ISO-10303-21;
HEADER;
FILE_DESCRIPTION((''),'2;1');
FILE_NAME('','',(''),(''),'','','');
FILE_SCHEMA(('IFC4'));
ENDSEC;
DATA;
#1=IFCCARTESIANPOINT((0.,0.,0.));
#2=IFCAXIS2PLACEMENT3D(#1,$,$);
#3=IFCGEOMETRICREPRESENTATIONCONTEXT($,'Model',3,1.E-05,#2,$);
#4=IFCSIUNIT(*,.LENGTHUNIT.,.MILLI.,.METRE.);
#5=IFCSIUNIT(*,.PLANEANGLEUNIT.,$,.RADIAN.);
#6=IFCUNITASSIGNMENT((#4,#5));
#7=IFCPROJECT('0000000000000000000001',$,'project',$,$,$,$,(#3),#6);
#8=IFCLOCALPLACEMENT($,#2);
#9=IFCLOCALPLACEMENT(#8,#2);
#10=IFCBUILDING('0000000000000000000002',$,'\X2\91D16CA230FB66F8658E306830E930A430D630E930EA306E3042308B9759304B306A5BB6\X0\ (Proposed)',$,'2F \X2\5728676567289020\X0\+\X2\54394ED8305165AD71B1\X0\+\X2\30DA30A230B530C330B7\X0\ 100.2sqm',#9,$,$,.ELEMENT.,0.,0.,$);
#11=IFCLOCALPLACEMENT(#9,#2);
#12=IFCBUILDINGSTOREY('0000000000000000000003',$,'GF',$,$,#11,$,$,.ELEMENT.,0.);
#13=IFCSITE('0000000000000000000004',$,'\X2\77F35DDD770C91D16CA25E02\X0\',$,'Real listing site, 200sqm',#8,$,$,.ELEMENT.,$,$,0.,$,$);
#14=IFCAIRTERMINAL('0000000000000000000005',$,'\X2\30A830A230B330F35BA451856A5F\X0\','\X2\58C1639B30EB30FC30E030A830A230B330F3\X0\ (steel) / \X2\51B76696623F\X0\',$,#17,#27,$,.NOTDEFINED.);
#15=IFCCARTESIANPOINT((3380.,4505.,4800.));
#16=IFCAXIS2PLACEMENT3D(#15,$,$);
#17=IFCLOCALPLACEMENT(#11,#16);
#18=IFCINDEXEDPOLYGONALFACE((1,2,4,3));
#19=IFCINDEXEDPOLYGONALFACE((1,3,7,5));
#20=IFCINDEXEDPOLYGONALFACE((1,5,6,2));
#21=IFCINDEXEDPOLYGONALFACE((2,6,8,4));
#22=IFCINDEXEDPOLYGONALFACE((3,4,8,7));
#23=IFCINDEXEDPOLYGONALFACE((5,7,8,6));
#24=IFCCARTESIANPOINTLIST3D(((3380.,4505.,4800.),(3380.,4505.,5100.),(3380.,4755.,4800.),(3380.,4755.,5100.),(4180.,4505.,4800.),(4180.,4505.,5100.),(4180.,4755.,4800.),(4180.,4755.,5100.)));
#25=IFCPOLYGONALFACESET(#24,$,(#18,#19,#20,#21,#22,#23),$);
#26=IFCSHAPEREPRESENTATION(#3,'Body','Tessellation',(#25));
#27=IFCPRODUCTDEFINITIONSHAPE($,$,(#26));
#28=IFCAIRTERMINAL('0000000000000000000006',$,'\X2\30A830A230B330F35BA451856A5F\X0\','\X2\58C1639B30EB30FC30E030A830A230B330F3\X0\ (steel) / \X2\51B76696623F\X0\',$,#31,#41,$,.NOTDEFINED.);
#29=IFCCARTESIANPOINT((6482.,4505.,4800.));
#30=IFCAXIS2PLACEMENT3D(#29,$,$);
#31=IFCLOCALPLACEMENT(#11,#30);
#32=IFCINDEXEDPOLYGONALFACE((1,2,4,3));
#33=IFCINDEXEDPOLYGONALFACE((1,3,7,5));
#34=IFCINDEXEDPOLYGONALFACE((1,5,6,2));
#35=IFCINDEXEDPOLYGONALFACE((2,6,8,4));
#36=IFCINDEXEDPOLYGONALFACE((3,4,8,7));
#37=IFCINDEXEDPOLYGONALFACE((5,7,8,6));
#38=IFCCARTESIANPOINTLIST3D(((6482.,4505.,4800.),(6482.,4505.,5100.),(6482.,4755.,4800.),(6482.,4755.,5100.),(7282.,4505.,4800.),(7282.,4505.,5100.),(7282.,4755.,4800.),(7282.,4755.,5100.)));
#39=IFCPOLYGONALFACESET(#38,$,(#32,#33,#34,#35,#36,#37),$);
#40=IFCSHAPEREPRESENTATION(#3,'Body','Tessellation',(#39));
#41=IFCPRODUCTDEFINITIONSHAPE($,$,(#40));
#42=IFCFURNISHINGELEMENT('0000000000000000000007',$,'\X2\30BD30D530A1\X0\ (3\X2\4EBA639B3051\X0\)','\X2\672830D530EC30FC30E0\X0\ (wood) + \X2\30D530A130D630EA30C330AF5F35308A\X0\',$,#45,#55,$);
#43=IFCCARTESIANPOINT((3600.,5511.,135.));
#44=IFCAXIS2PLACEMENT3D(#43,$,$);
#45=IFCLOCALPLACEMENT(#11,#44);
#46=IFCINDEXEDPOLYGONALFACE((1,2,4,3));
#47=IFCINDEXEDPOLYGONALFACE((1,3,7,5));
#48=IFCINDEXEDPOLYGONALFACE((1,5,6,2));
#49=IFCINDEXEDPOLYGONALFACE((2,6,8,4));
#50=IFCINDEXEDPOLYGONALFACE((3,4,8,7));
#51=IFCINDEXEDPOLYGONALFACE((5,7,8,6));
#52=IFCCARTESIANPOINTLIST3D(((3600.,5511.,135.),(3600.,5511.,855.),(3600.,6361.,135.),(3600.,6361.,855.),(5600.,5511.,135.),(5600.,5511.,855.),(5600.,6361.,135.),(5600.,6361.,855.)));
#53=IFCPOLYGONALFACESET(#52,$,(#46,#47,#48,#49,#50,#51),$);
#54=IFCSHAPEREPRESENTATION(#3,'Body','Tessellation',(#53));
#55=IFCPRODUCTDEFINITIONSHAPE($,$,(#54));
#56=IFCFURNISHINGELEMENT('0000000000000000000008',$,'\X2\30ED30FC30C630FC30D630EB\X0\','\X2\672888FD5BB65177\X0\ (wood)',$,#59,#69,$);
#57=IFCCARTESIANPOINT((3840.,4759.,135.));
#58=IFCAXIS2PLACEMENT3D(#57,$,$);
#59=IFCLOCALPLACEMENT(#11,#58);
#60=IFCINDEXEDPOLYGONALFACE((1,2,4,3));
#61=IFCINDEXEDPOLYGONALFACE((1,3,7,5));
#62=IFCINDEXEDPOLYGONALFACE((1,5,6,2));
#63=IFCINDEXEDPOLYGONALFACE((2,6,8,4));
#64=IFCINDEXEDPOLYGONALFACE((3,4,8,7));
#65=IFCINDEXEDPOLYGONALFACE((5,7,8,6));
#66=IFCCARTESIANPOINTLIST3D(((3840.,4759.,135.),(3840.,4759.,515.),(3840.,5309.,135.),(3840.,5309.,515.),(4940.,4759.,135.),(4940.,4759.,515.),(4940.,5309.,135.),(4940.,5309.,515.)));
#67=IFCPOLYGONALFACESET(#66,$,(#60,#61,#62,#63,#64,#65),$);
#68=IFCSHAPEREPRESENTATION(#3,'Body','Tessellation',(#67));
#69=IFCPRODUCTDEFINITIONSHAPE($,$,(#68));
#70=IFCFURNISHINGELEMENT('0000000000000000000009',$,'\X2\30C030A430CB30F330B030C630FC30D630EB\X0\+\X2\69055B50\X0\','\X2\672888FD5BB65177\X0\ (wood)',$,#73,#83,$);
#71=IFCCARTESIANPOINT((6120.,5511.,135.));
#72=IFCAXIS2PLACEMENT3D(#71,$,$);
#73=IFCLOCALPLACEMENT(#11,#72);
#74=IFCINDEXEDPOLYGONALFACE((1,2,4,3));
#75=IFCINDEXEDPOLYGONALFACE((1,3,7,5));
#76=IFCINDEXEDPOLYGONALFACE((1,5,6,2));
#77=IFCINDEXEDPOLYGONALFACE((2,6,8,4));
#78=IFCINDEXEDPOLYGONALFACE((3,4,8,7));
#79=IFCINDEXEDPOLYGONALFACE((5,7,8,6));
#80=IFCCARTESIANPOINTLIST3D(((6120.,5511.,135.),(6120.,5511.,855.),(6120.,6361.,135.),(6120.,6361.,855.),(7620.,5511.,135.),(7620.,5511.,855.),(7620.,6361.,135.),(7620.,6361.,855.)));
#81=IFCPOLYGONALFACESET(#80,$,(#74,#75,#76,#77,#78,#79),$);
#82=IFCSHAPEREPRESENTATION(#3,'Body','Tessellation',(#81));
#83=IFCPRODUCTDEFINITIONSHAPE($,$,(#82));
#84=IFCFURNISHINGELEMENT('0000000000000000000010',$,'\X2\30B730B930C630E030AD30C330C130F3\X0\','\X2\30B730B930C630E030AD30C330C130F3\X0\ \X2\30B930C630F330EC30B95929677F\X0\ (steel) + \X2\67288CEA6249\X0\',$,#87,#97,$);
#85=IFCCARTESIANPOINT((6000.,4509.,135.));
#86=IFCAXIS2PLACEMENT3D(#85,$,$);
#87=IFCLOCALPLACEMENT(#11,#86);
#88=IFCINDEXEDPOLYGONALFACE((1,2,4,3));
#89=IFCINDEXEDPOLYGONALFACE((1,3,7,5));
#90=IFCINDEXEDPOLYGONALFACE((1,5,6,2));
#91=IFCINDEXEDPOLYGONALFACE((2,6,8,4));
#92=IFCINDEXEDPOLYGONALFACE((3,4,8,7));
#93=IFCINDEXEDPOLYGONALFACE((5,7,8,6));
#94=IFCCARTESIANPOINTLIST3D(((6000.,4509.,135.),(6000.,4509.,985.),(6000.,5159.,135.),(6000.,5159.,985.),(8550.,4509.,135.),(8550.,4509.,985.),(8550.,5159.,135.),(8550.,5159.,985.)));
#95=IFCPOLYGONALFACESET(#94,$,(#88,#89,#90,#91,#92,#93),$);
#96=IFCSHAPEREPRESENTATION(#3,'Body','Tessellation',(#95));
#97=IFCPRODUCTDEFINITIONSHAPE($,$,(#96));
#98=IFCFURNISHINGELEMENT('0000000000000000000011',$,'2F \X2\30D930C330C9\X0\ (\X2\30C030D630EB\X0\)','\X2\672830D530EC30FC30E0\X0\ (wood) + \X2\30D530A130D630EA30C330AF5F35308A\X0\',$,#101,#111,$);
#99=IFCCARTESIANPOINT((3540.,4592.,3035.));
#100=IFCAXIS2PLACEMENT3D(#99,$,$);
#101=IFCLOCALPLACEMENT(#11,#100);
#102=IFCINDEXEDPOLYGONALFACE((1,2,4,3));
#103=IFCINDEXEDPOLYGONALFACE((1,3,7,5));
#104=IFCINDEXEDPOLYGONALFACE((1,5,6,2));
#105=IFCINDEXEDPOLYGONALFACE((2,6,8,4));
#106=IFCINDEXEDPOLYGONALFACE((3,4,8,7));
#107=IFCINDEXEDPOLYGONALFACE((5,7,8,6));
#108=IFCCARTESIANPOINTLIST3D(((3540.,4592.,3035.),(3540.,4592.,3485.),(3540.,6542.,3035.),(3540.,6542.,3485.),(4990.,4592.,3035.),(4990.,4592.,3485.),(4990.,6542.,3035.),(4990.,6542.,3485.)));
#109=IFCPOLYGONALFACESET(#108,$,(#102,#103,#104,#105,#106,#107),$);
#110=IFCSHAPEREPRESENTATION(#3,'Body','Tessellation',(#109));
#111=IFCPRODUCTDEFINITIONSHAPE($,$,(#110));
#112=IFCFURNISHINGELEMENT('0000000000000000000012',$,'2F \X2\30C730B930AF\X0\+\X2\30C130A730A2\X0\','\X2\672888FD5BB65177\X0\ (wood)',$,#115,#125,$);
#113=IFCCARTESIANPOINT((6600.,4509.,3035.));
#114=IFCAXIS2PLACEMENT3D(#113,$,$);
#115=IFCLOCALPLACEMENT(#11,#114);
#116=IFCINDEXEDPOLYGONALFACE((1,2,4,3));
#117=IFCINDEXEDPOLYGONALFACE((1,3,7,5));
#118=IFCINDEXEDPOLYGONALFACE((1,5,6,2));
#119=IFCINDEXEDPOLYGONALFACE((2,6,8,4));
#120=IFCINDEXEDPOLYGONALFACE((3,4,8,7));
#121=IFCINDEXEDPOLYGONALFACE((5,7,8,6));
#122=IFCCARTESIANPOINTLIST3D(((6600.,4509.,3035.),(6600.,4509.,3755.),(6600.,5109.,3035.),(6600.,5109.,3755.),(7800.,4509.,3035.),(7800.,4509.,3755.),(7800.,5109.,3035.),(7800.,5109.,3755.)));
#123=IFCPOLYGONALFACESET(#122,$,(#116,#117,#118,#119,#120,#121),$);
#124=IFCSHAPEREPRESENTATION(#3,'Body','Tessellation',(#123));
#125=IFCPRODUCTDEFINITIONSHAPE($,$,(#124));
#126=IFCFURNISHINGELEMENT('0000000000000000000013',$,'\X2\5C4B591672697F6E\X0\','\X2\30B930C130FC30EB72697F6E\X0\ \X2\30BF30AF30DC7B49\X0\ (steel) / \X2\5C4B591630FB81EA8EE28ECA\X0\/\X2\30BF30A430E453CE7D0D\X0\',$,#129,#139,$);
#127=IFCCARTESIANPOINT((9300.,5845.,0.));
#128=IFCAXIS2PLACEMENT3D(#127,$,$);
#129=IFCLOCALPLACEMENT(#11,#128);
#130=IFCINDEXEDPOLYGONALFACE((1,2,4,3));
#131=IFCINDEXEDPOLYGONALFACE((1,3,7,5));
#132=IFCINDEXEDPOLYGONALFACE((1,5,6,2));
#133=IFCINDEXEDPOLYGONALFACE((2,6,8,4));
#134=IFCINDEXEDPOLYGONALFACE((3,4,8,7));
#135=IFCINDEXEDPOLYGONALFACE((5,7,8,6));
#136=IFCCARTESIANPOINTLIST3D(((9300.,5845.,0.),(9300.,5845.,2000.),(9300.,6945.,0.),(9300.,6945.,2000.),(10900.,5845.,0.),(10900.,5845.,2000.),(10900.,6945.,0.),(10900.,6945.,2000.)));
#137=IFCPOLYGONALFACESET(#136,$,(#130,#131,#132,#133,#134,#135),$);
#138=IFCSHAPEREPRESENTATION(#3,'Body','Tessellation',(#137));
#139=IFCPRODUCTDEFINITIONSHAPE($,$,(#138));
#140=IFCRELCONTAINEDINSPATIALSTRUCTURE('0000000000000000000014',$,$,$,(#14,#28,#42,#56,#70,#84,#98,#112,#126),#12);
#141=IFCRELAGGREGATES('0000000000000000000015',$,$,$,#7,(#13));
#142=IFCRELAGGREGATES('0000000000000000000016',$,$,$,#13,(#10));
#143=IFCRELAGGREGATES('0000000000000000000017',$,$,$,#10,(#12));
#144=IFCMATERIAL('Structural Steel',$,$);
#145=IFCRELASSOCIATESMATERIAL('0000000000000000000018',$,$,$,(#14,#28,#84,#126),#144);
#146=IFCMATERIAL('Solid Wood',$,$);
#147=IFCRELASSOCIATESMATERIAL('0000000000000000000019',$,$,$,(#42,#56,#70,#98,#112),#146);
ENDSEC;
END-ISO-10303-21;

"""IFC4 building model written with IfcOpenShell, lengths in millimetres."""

from ifc_helpers import new_model, si_unit, frame, frame_2d, origin, place, context, project, spatial, rectangle, extrude, material, element, save


model = new_model("IFC4")

# Units and contexts
model_context = context("Model", 3, precision=1e-05, world=origin())
ifc_project = project(units=[si_unit("LENGTHUNIT", "METRE", prefix="MILLI"), si_unit("PLANEANGLEUNIT", "RADIAN")], contexts=[model_context])

# Site, building, storey
site_placement = place(None, origin())
site = spatial("IfcSite", under=ifc_project, at=site_placement, Name="石川県金沢市", ObjectType="Real listing site, 200sqm", CompositionType="ELEMENT", RefElevation=0.0)
building_placement = place(site_placement, origin())
building = spatial("IfcBuilding", under=site, at=building_placement, Name="金沢・書斎とライブラリのある静かな家 (Proposed)", ObjectType="2F 在来木造+吹付け断熱+ペアサッシ 100.2sqm", CompositionType="ELEMENT", ElevationOfRefHeight=0.0, ElevationOfTerrain=0.0)
storey_placement = place(building_placement, origin())
storey = spatial("IfcBuildingStorey", under=building, at=storey_placement, Name="GF", CompositionType="ELEMENT", Elevation=0.0)

# Shared definitions
ifc_material_1 = material(Name="Solid Wood")

# Shared definitions
ifc_material_2 = material(Name="Structural Steel")

# Air terminals
air_terminal_1_placement = place(storey_placement, frame((3380.0, 4505.0, 4800.0)))
element("IfcAirTerminal", 1, at=air_terminal_1_placement, inside=storey, material=ifc_material_2, Name="エアコン室内機", Description="壁掛ルームエアコン (steel) / 冷暖房", PredefinedType="NOTDEFINED", context=model_context, shape_type="SweptSolid", body=[
    extrude(rectangle(XDim=800.0, YDim=250.0, at=frame_2d((400.0, 125.0))), frame((3380.0, 4505.0, 4800.0)), (0.0, 0.0, 1.0), 300.0),
])
air_terminal_2_placement = place(storey_placement, frame((6482.0, 4505.0, 4800.0)))
element("IfcAirTerminal", 2, at=air_terminal_2_placement, inside=storey, material=ifc_material_2, Name="エアコン室内機", Description="壁掛ルームエアコン (steel) / 冷暖房", PredefinedType="NOTDEFINED", context=model_context, shape_type="SweptSolid", body=[
    extrude(rectangle(XDim=800.0, YDim=250.0, at=frame_2d((400.0, 125.0))), frame((6482.0, 4505.0, 4800.0)), (0.0, 0.0, 1.0), 300.0),
])

# Furnishing elements
furnishing_1_placement = place(storey_placement, frame((3600.0, 5511.0, 135.0)))
element("IfcFurnishingElement", 3, at=furnishing_1_placement, inside=storey, material=ifc_material_1, Name="ソファ (3人掛け)", Description="木フレーム (wood) + ファブリック張り", context=model_context, shape_type="SweptSolid", body=[
    extrude(rectangle(XDim=2000.0, YDim=850.0, at=frame_2d((1000.0, 425.0))), frame((3600.0, 5511.0, 135.0)), (0.0, 0.0, 1.0), 720.0),
])
furnishing_2_placement = place(storey_placement, frame((3840.0, 4759.0, 135.0)))
element("IfcFurnishingElement", 4, at=furnishing_2_placement, inside=storey, material=ifc_material_1, Name="ローテーブル", Description="木製家具 (wood)", context=model_context, shape_type="SweptSolid", body=[
    extrude(rectangle(XDim=1100.0, YDim=550.0, at=frame_2d((550.0, 275.0))), frame((3840.0, 4759.0, 135.0)), (0.0, 0.0, 1.0), 380.0),
])
furnishing_3_placement = place(storey_placement, frame((6120.0, 5511.0, 135.0)))
element("IfcFurnishingElement", 5, at=furnishing_3_placement, inside=storey, material=ifc_material_1, Name="ダイニングテーブル+椅子", Description="木製家具 (wood)", context=model_context, shape_type="SweptSolid", body=[
    extrude(rectangle(XDim=1500.0, YDim=850.0, at=frame_2d((750.0, 425.0))), frame((6120.0, 5511.0, 135.0)), (0.0, 0.0, 1.0), 720.0),
])
furnishing_4_placement = place(storey_placement, frame((6000.0, 4509.0, 135.0)))
element("IfcFurnishingElement", 6, at=furnishing_4_placement, inside=storey, material=ifc_material_2, Name="システムキッチン", Description="システムキッチン ステンレス天板 (steel) + 木質扉", context=model_context, shape_type="SweptSolid", body=[
    extrude(rectangle(XDim=2550.0, YDim=650.0, at=frame_2d((1275.0, 325.0))), frame((6000.0, 4509.0, 135.0)), (0.0, 0.0, 1.0), 850.0),
])
furnishing_5_placement = place(storey_placement, frame((3540.0, 4592.0, 3035.0)))
element("IfcFurnishingElement", 7, at=furnishing_5_placement, inside=storey, material=ifc_material_1, Name="2F ベッド (ダブル)", Description="木フレーム (wood) + ファブリック張り", context=model_context, shape_type="SweptSolid", body=[
    extrude(rectangle(XDim=1450.0, YDim=1950.0, at=frame_2d((725.0, 975.0))), frame((3540.0, 4592.0, 3035.0)), (0.0, 0.0, 1.0), 450.0),
])
furnishing_6_placement = place(storey_placement, frame((6600.0, 4509.0, 3035.0)))
element("IfcFurnishingElement", 8, at=furnishing_6_placement, inside=storey, material=ifc_material_1, Name="2F デスク+チェア", Description="木製家具 (wood)", context=model_context, shape_type="SweptSolid", body=[
    extrude(rectangle(XDim=1200.0, YDim=600.0, at=frame_2d((600.0, 300.0))), frame((6600.0, 4509.0, 3035.0)), (0.0, 0.0, 1.0), 720.0),
])
furnishing_7_placement = place(storey_placement, frame((9300.0, 5845.0, 0.0)))
element("IfcFurnishingElement", 9, at=furnishing_7_placement, inside=storey, material=ifc_material_2, Name="屋外物置", Description="スチール物置 タクボ等 (steel) / 屋外・自転車/タイヤ収納", context=model_context, shape_type="SweptSolid", body=[
    extrude(rectangle(XDim=1600.0, YDim=1100.0, at=frame_2d((800.0, 550.0))), frame((9300.0, 5845.0, 0.0)), (0.0, 0.0, 1.0), 2000.0),
])

save(model, "model.ifc")
